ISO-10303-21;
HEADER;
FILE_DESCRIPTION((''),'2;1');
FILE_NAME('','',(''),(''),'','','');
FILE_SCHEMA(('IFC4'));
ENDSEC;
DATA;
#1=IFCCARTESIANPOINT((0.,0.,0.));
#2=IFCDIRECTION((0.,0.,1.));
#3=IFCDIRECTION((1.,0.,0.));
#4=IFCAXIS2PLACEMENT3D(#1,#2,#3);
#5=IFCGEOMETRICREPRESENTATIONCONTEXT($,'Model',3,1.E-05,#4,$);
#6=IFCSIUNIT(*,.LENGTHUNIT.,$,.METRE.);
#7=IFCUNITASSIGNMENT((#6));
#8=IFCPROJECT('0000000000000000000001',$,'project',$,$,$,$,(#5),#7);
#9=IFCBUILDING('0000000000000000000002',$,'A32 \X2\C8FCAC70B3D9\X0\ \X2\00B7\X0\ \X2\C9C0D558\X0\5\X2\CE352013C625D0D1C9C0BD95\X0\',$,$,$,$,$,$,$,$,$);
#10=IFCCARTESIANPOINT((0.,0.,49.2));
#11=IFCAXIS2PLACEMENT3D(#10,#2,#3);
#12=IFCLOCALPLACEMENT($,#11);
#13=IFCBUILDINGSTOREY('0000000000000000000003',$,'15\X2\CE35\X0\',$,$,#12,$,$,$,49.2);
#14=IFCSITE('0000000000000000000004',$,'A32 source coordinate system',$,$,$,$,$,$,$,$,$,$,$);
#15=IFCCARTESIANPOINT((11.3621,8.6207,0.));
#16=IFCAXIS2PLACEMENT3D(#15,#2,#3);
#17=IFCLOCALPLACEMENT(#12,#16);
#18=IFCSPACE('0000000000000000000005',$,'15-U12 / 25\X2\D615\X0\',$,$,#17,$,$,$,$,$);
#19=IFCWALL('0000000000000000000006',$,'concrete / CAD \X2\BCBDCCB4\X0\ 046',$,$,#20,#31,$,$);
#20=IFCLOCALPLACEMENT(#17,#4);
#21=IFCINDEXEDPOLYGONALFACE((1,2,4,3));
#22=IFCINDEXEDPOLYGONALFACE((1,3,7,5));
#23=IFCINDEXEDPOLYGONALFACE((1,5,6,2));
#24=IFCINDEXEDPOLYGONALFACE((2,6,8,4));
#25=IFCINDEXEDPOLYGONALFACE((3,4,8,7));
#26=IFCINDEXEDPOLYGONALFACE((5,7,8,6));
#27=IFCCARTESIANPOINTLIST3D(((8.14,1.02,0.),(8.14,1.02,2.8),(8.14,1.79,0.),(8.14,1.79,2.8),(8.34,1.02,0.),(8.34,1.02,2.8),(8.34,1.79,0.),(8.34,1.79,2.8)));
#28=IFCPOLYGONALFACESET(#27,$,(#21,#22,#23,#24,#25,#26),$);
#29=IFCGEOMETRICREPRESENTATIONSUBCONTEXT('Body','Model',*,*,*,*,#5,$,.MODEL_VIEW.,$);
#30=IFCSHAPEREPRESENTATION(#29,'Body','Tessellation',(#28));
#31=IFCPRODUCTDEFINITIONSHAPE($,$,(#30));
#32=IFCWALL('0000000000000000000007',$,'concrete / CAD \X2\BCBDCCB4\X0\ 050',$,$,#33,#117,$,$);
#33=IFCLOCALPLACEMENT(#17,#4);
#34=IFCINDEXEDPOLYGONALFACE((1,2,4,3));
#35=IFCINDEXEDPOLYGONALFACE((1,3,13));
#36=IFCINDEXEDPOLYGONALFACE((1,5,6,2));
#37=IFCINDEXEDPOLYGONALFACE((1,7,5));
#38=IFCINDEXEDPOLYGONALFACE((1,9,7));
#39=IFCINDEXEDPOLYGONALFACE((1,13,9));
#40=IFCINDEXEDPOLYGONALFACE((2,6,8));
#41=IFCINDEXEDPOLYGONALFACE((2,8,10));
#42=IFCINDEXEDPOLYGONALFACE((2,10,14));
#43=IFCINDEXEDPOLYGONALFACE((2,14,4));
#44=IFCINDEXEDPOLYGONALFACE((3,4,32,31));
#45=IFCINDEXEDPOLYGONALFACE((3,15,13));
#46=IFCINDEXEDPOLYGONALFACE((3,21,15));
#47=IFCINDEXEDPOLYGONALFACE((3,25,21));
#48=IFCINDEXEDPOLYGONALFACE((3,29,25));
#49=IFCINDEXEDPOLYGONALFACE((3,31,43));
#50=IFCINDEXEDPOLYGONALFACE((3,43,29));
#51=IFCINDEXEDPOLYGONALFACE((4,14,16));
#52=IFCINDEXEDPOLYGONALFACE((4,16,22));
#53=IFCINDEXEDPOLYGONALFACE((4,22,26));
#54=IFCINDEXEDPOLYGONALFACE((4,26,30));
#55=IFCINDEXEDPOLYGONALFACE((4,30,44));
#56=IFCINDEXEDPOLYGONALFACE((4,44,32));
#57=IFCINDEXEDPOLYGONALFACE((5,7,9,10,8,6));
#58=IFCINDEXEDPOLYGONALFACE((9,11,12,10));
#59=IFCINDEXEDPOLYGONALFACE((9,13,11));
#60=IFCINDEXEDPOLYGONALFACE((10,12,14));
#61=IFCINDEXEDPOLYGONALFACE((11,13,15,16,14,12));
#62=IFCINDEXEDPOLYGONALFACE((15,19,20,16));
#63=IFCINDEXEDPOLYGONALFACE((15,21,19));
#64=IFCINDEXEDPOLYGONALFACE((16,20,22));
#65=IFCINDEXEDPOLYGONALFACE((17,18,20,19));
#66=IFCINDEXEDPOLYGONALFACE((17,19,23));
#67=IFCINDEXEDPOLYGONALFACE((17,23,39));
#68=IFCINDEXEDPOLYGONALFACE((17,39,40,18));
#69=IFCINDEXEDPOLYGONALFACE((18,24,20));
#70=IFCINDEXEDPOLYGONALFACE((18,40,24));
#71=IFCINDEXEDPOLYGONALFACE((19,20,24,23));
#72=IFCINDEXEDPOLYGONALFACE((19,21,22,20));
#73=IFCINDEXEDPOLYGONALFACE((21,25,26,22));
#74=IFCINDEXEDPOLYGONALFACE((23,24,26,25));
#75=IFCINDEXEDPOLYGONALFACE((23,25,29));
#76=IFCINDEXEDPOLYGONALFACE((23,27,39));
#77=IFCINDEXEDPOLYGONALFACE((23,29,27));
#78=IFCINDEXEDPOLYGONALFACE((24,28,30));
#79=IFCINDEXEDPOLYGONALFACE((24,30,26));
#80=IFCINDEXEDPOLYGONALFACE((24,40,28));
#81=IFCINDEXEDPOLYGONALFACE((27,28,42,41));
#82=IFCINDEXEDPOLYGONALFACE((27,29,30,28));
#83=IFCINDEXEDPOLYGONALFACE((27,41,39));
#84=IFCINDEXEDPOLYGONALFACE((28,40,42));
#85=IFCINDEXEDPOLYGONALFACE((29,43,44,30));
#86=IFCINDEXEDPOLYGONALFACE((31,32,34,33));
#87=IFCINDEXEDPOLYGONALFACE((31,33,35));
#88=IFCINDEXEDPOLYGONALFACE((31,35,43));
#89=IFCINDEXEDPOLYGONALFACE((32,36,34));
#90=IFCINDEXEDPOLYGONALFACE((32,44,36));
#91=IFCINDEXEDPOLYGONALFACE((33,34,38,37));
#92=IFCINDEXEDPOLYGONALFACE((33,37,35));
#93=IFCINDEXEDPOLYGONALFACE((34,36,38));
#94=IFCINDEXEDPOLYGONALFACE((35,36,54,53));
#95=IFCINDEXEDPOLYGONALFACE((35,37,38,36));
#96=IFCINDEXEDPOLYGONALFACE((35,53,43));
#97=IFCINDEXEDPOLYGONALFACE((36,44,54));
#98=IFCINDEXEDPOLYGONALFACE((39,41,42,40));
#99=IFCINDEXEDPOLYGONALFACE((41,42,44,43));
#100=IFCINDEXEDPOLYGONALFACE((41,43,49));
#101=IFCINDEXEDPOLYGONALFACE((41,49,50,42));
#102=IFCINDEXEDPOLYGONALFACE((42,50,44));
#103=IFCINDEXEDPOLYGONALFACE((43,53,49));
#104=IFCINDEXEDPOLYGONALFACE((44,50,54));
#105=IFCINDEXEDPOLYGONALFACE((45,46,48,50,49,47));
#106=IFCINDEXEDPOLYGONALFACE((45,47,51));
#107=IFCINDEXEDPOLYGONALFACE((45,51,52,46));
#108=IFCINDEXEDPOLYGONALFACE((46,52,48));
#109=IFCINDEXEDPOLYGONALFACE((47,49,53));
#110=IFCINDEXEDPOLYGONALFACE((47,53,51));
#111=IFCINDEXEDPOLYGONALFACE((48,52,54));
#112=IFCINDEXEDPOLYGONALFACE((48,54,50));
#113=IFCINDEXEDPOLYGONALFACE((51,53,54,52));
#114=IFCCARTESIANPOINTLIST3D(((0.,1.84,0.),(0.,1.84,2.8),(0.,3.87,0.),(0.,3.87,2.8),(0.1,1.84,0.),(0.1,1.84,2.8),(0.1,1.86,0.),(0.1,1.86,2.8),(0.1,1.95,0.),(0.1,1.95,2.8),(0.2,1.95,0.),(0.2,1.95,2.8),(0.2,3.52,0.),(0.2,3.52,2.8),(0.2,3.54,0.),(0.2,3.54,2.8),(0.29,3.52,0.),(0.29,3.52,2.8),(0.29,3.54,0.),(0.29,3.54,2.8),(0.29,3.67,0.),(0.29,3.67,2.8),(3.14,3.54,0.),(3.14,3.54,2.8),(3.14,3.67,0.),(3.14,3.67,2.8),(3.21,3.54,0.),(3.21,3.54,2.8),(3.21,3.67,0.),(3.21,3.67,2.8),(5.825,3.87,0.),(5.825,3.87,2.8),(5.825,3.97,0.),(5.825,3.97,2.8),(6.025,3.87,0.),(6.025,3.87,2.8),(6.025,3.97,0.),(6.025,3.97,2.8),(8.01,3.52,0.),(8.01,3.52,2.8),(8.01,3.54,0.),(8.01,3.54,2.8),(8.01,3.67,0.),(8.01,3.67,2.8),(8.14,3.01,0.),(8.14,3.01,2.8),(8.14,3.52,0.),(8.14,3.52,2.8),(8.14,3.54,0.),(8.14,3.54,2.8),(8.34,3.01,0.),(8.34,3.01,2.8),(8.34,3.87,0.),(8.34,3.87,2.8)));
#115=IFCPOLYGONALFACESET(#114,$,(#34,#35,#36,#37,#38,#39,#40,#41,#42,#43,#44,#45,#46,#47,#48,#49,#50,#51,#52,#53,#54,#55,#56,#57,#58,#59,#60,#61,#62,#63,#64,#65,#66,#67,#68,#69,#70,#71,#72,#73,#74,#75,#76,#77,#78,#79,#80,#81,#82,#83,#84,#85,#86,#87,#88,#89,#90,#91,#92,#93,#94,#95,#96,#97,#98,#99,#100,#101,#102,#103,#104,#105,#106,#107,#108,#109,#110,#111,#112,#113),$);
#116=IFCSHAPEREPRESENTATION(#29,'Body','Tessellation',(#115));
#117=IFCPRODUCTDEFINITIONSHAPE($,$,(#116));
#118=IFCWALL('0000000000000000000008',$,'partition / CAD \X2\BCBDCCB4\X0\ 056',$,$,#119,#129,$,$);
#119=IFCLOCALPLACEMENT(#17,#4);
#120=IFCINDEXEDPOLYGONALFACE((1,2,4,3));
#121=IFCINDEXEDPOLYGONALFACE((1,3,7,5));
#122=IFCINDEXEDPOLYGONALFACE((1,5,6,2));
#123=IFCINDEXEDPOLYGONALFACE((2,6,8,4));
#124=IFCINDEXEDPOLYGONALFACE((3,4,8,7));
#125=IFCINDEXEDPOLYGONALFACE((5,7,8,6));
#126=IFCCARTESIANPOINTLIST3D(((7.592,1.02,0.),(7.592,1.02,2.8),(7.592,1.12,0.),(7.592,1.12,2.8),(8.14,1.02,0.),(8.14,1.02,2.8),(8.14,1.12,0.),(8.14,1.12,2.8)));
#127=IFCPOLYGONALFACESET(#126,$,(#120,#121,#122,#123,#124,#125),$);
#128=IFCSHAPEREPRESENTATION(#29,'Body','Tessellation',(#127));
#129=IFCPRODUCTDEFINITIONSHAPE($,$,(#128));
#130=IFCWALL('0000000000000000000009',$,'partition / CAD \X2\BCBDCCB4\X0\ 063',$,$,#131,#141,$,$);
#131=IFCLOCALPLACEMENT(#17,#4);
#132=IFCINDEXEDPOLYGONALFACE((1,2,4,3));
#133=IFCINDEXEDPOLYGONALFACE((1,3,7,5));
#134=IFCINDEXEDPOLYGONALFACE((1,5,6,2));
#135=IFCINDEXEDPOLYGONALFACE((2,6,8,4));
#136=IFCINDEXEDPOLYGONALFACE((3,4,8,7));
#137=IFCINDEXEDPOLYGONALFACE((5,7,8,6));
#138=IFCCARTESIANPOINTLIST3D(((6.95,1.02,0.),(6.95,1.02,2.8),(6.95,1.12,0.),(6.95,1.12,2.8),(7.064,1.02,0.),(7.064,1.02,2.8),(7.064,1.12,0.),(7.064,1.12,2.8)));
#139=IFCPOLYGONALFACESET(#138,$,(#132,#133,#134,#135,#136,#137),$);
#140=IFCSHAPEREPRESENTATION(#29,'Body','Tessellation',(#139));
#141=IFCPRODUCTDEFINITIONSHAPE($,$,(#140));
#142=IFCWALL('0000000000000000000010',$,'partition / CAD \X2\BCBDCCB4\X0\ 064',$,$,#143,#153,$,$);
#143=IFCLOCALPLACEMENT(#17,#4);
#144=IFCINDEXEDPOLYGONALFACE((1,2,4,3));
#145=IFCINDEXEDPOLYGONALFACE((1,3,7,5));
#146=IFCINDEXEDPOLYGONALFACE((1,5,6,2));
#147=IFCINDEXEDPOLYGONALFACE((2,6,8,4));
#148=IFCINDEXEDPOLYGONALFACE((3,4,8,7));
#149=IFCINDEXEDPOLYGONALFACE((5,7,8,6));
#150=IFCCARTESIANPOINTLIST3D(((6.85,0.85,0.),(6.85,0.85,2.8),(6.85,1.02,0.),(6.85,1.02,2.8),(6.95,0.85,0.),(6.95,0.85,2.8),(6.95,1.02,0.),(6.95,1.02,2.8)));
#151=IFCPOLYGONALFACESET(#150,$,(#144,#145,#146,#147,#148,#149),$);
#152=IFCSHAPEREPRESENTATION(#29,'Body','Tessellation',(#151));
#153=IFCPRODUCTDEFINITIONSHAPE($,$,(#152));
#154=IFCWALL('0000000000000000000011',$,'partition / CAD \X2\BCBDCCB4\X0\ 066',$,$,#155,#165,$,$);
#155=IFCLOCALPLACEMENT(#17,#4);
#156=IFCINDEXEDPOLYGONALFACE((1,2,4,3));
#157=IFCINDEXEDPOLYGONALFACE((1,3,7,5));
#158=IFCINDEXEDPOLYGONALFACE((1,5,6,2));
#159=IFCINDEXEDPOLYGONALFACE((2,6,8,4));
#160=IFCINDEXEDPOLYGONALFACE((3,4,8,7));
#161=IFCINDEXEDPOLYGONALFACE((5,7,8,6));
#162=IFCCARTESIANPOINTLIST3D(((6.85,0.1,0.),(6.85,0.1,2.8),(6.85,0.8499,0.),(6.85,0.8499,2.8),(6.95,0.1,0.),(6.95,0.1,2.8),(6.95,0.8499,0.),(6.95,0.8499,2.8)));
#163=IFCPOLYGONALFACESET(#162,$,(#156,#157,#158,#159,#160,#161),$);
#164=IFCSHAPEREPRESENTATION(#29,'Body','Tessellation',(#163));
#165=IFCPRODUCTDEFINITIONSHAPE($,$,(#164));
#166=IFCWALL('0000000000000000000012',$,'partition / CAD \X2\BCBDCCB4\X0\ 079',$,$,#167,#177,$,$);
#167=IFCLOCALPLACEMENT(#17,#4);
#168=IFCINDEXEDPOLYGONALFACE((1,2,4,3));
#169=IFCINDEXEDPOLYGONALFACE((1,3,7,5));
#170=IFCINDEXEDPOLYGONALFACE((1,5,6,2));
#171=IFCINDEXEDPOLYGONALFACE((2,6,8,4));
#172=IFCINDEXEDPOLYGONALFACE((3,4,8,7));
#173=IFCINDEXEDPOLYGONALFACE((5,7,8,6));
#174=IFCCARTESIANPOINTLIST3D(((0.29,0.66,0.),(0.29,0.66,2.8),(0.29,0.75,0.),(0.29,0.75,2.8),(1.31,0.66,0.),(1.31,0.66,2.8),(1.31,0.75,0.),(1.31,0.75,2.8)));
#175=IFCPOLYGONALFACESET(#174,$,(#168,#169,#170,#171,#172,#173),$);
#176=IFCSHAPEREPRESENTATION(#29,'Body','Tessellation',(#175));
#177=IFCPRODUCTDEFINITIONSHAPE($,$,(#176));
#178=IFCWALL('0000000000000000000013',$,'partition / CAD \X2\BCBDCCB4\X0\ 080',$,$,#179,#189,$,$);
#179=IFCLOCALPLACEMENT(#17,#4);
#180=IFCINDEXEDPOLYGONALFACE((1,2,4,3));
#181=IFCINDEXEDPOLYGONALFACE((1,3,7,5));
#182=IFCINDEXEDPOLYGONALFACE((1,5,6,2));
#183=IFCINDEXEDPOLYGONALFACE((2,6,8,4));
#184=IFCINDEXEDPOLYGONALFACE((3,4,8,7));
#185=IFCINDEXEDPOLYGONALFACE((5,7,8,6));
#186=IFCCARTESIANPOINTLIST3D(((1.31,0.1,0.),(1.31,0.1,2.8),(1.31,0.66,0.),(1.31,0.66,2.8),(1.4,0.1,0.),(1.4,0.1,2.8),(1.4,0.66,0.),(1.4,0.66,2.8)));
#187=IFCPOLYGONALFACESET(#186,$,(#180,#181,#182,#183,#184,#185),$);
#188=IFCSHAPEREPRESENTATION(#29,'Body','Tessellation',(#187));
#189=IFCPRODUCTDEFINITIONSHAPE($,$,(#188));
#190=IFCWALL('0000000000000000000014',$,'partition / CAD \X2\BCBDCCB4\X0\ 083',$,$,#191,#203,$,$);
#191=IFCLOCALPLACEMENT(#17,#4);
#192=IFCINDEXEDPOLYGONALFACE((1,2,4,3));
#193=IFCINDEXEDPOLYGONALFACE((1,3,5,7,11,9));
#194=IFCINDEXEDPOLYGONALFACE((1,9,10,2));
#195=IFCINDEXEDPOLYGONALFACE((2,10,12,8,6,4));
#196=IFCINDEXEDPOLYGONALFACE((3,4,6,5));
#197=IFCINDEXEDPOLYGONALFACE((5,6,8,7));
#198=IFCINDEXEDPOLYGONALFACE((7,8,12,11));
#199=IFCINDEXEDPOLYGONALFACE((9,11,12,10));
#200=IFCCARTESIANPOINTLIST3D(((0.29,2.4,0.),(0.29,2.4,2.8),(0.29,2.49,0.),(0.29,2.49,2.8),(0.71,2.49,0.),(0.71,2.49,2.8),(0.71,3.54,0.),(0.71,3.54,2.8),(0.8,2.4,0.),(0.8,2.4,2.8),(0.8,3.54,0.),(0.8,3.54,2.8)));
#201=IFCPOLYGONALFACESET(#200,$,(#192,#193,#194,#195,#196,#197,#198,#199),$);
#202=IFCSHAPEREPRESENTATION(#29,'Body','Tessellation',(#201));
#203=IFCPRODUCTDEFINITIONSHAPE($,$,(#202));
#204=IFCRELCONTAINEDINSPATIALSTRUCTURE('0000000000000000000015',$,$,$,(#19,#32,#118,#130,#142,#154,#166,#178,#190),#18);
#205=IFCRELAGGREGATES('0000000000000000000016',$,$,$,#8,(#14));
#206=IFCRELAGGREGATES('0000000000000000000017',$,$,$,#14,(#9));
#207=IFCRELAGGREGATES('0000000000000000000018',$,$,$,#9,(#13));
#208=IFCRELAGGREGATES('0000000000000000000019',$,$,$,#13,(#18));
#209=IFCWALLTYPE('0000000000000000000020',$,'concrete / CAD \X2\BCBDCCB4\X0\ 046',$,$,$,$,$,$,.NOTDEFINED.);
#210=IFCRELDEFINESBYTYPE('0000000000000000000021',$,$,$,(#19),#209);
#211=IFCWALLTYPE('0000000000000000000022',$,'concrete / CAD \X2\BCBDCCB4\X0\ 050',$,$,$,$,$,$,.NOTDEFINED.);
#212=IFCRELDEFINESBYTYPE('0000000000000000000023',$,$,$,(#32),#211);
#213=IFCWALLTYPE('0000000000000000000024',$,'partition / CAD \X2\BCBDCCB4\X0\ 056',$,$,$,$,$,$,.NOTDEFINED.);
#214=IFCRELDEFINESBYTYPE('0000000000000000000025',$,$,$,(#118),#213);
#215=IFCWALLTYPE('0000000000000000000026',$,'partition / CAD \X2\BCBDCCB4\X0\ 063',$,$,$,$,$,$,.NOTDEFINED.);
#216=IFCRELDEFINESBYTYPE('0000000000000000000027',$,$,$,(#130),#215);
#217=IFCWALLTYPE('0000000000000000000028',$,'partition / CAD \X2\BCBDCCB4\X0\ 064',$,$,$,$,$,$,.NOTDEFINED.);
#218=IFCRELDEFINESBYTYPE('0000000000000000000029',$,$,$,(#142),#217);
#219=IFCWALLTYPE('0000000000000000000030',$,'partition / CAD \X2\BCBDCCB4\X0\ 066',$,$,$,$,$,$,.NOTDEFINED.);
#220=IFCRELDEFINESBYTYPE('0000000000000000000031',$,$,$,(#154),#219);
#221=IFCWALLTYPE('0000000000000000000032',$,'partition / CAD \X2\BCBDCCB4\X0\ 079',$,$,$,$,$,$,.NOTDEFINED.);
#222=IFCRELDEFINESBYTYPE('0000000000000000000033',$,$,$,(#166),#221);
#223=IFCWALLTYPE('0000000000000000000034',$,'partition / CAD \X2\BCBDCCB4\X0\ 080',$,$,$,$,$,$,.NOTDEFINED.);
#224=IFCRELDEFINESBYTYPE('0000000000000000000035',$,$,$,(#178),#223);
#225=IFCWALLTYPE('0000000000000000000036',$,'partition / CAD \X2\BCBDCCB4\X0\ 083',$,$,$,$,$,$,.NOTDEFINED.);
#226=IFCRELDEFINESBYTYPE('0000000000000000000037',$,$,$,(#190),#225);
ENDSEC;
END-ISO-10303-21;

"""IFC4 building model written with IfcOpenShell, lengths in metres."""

from ifc_helpers import new_model, si_unit, frame, origin, origin_with_axes, place, context, subcontext, project, spatial, polyline, outline, extrude, source, transform, mapped, type_object, type_shapes, element, save


model = new_model("IFC4")

# Units and contexts
model_context = context("Model", 3, precision=1e-05, world=origin_with_axes())
body_context = subcontext(model_context, "Body", "Model", "MODEL_VIEW")
ifc_project = project(units=[si_unit("LENGTHUNIT", "METRE")], contexts=[model_context])

# Site, building, storey, space
site = spatial("IfcSite", under=ifc_project, Name="A32 source coordinate system")
building = spatial("IfcBuilding", under=site, Name="A32 주거동 · 지하5층–옥탑지붕")
storey_placement = place(None, frame((0.0, 0.0, 49.2), z_axis=(0.0, 0.0, 1.0), x_axis=(1.0, 0.0, 0.0)))
storey = spatial("IfcBuildingStorey", under=building, at=storey_placement, Name="15층", Elevation=49.2)
space_1_placement = place(storey_placement, frame((11.3621, 8.6207, 0.0), z_axis=(0.0, 0.0, 1.0), x_axis=(1.0, 0.0, 0.0)))
space_1 = spatial("IfcSpace", under=storey, at=space_1_placement, Name="15-U12 / 25형")

# Walls
wall_type_1 = type_object("IfcWallType", Name="concrete / CAD 벽체 046", PredefinedType="NOTDEFINED")
shared_shape_1 = source(origin(), body_context, "Body", "SweptSolid", [
    extrude(outline(polyline([(8.14, 1.02), (8.14, 1.79), (8.34, 1.79), (8.34, 1.02), (8.14, 1.02)])), origin(), (0.0, 0.0, 1.0), 2.8),
])
type_shapes(wall_type_1, [shared_shape_1])
wall_1_placement = place(space_1_placement, origin_with_axes())
element("IfcWall", 1, at=wall_1_placement, inside=space_1, type_object=wall_type_1, Name="concrete / CAD 벽체 046", context=body_context, shape_type="MappedRepresentation", body=[
    mapped(shared_shape_1, transform((0.0, 0.0, 0.0), scale=1.0)),
])
wall_type_2 = type_object("IfcWallType", Name="concrete / CAD 벽체 050", PredefinedType="NOTDEFINED")
shared_shape_2 = source(origin(), body_context, "Body", "SweptSolid", [
    extrude(outline(polyline([(8.01, 3.52), (0.29, 3.52), (0.29, 3.54), (0.2, 3.54), (0.2, 3.52), (0.2, 1.95), (0.1, 1.95), (0.1, 1.86), (0.1, 1.84), (0.0, 1.84), (0.0, 3.87), (5.825, 3.87), (5.825, 3.97), (6.025, 3.97), (6.025, 3.87), (8.34, 3.87), (8.34, 3.01), (8.14, 3.01), (8.14, 3.52), (8.14, 3.54), (8.01, 3.54), (8.01, 3.52)]), holes=[polyline([(3.14, 3.54), (3.14, 3.67), (0.29, 3.67), (0.29, 3.54), (3.14, 3.54)]), polyline([(8.01, 3.67), (3.21, 3.67), (3.21, 3.54), (8.01, 3.54), (8.01, 3.67)])]), origin(), (0.0, 0.0, 1.0), 2.8),
])
type_shapes(wall_type_2, [shared_shape_2])
wall_2_placement = place(space_1_placement, origin_with_axes())
element("IfcWall", 2, at=wall_2_placement, inside=space_1, type_object=wall_type_2, Name="concrete / CAD 벽체 050", context=body_context, shape_type="MappedRepresentation", body=[
    mapped(shared_shape_2, transform((0.0, 0.0, 0.0), scale=1.0)),
])
wall_type_3 = type_object("IfcWallType", Name="partition / CAD 벽체 056", PredefinedType="NOTDEFINED")
shared_shape_3 = source(origin(), body_context, "Body", "SweptSolid", [
    extrude(outline(polyline([(7.592, 1.12), (8.14, 1.12), (8.14, 1.02), (7.592, 1.02), (7.592, 1.12)])), origin(), (0.0, 0.0, 1.0), 2.8),
])
type_shapes(wall_type_3, [shared_shape_3])
wall_3_placement = place(space_1_placement, origin_with_axes())
element("IfcWall", 3, at=wall_3_placement, inside=space_1, type_object=wall_type_3, Name="partition / CAD 벽체 056", context=body_context, shape_type="MappedRepresentation", body=[
    mapped(shared_shape_3, transform((0.0, 0.0, 0.0), scale=1.0)),
])
wall_type_4 = type_object("IfcWallType", Name="partition / CAD 벽체 063", PredefinedType="NOTDEFINED")
shared_shape_4 = source(origin(), body_context, "Body", "SweptSolid", [
    extrude(outline(polyline([(6.95, 1.12), (7.064, 1.12), (7.064, 1.02), (6.95, 1.02), (6.95, 1.12)])), origin(), (0.0, 0.0, 1.0), 2.8),
])
type_shapes(wall_type_4, [shared_shape_4])
wall_4_placement = place(space_1_placement, origin_with_axes())
element("IfcWall", 4, at=wall_4_placement, inside=space_1, type_object=wall_type_4, Name="partition / CAD 벽체 063", context=body_context, shape_type="MappedRepresentation", body=[
    mapped(shared_shape_4, transform((0.0, 0.0, 0.0), scale=1.0)),
])
wall_type_5 = type_object("IfcWallType", Name="partition / CAD 벽체 064", PredefinedType="NOTDEFINED")
shared_shape_5 = source(origin(), body_context, "Body", "SweptSolid", [
    extrude(outline(polyline([(6.95, 0.85), (6.85, 0.85), (6.85, 1.02), (6.95, 1.02), (6.95, 0.85)])), origin(), (0.0, 0.0, 1.0), 2.8),
])
type_shapes(wall_type_5, [shared_shape_5])
wall_5_placement = place(space_1_placement, origin_with_axes())
element("IfcWall", 5, at=wall_5_placement, inside=space_1, type_object=wall_type_5, Name="partition / CAD 벽체 064", context=body_context, shape_type="MappedRepresentation", body=[
    mapped(shared_shape_5, transform((0.0, 0.0, 0.0), scale=1.0)),
])
wall_type_6 = type_object("IfcWallType", Name="partition / CAD 벽체 066", PredefinedType="NOTDEFINED")
shared_shape_6 = source(origin(), body_context, "Body", "SweptSolid", [
    extrude(outline(polyline([(6.85, 0.8499), (6.95, 0.8499), (6.95, 0.1), (6.85, 0.1), (6.85, 0.8499)])), origin(), (0.0, 0.0, 1.0), 2.8),
])
type_shapes(wall_type_6, [shared_shape_6])
wall_6_placement = place(space_1_placement, origin_with_axes())
element("IfcWall", 6, at=wall_6_placement, inside=space_1, type_object=wall_type_6, Name="partition / CAD 벽체 066", context=body_context, shape_type="MappedRepresentation", body=[
    mapped(shared_shape_6, transform((0.0, 0.0, 0.0), scale=1.0)),
])
wall_type_7 = type_object("IfcWallType", Name="partition / CAD 벽체 079", PredefinedType="NOTDEFINED")
shared_shape_7 = source(origin(), body_context, "Body", "SweptSolid", [
    extrude(outline(polyline([(0.29, 0.75), (1.31, 0.75), (1.31, 0.66), (0.29, 0.66), (0.29, 0.75)])), origin(), (0.0, 0.0, 1.0), 2.8),
])
type_shapes(wall_type_7, [shared_shape_7])
wall_7_placement = place(space_1_placement, origin_with_axes())
element("IfcWall", 7, at=wall_7_placement, inside=space_1, type_object=wall_type_7, Name="partition / CAD 벽체 079", context=body_context, shape_type="MappedRepresentation", body=[
    mapped(shared_shape_7, transform((0.0, 0.0, 0.0), scale=1.0)),
])
wall_type_8 = type_object("IfcWallType", Name="partition / CAD 벽체 080", PredefinedType="NOTDEFINED")
shared_shape_8 = source(origin(), body_context, "Body", "SweptSolid", [
    extrude(outline(polyline([(1.4, 0.66), (1.4, 0.1), (1.31, 0.1), (1.31, 0.66), (1.4, 0.66)])), origin(), (0.0, 0.0, 1.0), 2.8),
])
type_shapes(wall_type_8, [shared_shape_8])
wall_8_placement = place(space_1_placement, origin_with_axes())
element("IfcWall", 8, at=wall_8_placement, inside=space_1, type_object=wall_type_8, Name="partition / CAD 벽체 080", context=body_context, shape_type="MappedRepresentation", body=[
    mapped(shared_shape_8, transform((0.0, 0.0, 0.0), scale=1.0)),
])
wall_type_9 = type_object("IfcWallType", Name="partition / CAD 벽체 083", PredefinedType="NOTDEFINED")
shared_shape_9 = source(origin(), body_context, "Body", "SweptSolid", [
    extrude(outline(polyline([(0.71, 2.49), (0.71, 3.54), (0.8, 3.54), (0.8, 2.4), (0.29, 2.4), (0.29, 2.49), (0.71, 2.49)])), origin(), (0.0, 0.0, 1.0), 2.8),
])
type_shapes(wall_type_9, [shared_shape_9])
wall_9_placement = place(space_1_placement, origin_with_axes())
element("IfcWall", 9, at=wall_9_placement, inside=space_1, type_object=wall_type_9, Name="partition / CAD 벽체 083", context=body_context, shape_type="MappedRepresentation", body=[
    mapped(shared_shape_9, transform((0.0, 0.0, 0.0), scale=1.0)),
])

save(model, "model.ifc")
